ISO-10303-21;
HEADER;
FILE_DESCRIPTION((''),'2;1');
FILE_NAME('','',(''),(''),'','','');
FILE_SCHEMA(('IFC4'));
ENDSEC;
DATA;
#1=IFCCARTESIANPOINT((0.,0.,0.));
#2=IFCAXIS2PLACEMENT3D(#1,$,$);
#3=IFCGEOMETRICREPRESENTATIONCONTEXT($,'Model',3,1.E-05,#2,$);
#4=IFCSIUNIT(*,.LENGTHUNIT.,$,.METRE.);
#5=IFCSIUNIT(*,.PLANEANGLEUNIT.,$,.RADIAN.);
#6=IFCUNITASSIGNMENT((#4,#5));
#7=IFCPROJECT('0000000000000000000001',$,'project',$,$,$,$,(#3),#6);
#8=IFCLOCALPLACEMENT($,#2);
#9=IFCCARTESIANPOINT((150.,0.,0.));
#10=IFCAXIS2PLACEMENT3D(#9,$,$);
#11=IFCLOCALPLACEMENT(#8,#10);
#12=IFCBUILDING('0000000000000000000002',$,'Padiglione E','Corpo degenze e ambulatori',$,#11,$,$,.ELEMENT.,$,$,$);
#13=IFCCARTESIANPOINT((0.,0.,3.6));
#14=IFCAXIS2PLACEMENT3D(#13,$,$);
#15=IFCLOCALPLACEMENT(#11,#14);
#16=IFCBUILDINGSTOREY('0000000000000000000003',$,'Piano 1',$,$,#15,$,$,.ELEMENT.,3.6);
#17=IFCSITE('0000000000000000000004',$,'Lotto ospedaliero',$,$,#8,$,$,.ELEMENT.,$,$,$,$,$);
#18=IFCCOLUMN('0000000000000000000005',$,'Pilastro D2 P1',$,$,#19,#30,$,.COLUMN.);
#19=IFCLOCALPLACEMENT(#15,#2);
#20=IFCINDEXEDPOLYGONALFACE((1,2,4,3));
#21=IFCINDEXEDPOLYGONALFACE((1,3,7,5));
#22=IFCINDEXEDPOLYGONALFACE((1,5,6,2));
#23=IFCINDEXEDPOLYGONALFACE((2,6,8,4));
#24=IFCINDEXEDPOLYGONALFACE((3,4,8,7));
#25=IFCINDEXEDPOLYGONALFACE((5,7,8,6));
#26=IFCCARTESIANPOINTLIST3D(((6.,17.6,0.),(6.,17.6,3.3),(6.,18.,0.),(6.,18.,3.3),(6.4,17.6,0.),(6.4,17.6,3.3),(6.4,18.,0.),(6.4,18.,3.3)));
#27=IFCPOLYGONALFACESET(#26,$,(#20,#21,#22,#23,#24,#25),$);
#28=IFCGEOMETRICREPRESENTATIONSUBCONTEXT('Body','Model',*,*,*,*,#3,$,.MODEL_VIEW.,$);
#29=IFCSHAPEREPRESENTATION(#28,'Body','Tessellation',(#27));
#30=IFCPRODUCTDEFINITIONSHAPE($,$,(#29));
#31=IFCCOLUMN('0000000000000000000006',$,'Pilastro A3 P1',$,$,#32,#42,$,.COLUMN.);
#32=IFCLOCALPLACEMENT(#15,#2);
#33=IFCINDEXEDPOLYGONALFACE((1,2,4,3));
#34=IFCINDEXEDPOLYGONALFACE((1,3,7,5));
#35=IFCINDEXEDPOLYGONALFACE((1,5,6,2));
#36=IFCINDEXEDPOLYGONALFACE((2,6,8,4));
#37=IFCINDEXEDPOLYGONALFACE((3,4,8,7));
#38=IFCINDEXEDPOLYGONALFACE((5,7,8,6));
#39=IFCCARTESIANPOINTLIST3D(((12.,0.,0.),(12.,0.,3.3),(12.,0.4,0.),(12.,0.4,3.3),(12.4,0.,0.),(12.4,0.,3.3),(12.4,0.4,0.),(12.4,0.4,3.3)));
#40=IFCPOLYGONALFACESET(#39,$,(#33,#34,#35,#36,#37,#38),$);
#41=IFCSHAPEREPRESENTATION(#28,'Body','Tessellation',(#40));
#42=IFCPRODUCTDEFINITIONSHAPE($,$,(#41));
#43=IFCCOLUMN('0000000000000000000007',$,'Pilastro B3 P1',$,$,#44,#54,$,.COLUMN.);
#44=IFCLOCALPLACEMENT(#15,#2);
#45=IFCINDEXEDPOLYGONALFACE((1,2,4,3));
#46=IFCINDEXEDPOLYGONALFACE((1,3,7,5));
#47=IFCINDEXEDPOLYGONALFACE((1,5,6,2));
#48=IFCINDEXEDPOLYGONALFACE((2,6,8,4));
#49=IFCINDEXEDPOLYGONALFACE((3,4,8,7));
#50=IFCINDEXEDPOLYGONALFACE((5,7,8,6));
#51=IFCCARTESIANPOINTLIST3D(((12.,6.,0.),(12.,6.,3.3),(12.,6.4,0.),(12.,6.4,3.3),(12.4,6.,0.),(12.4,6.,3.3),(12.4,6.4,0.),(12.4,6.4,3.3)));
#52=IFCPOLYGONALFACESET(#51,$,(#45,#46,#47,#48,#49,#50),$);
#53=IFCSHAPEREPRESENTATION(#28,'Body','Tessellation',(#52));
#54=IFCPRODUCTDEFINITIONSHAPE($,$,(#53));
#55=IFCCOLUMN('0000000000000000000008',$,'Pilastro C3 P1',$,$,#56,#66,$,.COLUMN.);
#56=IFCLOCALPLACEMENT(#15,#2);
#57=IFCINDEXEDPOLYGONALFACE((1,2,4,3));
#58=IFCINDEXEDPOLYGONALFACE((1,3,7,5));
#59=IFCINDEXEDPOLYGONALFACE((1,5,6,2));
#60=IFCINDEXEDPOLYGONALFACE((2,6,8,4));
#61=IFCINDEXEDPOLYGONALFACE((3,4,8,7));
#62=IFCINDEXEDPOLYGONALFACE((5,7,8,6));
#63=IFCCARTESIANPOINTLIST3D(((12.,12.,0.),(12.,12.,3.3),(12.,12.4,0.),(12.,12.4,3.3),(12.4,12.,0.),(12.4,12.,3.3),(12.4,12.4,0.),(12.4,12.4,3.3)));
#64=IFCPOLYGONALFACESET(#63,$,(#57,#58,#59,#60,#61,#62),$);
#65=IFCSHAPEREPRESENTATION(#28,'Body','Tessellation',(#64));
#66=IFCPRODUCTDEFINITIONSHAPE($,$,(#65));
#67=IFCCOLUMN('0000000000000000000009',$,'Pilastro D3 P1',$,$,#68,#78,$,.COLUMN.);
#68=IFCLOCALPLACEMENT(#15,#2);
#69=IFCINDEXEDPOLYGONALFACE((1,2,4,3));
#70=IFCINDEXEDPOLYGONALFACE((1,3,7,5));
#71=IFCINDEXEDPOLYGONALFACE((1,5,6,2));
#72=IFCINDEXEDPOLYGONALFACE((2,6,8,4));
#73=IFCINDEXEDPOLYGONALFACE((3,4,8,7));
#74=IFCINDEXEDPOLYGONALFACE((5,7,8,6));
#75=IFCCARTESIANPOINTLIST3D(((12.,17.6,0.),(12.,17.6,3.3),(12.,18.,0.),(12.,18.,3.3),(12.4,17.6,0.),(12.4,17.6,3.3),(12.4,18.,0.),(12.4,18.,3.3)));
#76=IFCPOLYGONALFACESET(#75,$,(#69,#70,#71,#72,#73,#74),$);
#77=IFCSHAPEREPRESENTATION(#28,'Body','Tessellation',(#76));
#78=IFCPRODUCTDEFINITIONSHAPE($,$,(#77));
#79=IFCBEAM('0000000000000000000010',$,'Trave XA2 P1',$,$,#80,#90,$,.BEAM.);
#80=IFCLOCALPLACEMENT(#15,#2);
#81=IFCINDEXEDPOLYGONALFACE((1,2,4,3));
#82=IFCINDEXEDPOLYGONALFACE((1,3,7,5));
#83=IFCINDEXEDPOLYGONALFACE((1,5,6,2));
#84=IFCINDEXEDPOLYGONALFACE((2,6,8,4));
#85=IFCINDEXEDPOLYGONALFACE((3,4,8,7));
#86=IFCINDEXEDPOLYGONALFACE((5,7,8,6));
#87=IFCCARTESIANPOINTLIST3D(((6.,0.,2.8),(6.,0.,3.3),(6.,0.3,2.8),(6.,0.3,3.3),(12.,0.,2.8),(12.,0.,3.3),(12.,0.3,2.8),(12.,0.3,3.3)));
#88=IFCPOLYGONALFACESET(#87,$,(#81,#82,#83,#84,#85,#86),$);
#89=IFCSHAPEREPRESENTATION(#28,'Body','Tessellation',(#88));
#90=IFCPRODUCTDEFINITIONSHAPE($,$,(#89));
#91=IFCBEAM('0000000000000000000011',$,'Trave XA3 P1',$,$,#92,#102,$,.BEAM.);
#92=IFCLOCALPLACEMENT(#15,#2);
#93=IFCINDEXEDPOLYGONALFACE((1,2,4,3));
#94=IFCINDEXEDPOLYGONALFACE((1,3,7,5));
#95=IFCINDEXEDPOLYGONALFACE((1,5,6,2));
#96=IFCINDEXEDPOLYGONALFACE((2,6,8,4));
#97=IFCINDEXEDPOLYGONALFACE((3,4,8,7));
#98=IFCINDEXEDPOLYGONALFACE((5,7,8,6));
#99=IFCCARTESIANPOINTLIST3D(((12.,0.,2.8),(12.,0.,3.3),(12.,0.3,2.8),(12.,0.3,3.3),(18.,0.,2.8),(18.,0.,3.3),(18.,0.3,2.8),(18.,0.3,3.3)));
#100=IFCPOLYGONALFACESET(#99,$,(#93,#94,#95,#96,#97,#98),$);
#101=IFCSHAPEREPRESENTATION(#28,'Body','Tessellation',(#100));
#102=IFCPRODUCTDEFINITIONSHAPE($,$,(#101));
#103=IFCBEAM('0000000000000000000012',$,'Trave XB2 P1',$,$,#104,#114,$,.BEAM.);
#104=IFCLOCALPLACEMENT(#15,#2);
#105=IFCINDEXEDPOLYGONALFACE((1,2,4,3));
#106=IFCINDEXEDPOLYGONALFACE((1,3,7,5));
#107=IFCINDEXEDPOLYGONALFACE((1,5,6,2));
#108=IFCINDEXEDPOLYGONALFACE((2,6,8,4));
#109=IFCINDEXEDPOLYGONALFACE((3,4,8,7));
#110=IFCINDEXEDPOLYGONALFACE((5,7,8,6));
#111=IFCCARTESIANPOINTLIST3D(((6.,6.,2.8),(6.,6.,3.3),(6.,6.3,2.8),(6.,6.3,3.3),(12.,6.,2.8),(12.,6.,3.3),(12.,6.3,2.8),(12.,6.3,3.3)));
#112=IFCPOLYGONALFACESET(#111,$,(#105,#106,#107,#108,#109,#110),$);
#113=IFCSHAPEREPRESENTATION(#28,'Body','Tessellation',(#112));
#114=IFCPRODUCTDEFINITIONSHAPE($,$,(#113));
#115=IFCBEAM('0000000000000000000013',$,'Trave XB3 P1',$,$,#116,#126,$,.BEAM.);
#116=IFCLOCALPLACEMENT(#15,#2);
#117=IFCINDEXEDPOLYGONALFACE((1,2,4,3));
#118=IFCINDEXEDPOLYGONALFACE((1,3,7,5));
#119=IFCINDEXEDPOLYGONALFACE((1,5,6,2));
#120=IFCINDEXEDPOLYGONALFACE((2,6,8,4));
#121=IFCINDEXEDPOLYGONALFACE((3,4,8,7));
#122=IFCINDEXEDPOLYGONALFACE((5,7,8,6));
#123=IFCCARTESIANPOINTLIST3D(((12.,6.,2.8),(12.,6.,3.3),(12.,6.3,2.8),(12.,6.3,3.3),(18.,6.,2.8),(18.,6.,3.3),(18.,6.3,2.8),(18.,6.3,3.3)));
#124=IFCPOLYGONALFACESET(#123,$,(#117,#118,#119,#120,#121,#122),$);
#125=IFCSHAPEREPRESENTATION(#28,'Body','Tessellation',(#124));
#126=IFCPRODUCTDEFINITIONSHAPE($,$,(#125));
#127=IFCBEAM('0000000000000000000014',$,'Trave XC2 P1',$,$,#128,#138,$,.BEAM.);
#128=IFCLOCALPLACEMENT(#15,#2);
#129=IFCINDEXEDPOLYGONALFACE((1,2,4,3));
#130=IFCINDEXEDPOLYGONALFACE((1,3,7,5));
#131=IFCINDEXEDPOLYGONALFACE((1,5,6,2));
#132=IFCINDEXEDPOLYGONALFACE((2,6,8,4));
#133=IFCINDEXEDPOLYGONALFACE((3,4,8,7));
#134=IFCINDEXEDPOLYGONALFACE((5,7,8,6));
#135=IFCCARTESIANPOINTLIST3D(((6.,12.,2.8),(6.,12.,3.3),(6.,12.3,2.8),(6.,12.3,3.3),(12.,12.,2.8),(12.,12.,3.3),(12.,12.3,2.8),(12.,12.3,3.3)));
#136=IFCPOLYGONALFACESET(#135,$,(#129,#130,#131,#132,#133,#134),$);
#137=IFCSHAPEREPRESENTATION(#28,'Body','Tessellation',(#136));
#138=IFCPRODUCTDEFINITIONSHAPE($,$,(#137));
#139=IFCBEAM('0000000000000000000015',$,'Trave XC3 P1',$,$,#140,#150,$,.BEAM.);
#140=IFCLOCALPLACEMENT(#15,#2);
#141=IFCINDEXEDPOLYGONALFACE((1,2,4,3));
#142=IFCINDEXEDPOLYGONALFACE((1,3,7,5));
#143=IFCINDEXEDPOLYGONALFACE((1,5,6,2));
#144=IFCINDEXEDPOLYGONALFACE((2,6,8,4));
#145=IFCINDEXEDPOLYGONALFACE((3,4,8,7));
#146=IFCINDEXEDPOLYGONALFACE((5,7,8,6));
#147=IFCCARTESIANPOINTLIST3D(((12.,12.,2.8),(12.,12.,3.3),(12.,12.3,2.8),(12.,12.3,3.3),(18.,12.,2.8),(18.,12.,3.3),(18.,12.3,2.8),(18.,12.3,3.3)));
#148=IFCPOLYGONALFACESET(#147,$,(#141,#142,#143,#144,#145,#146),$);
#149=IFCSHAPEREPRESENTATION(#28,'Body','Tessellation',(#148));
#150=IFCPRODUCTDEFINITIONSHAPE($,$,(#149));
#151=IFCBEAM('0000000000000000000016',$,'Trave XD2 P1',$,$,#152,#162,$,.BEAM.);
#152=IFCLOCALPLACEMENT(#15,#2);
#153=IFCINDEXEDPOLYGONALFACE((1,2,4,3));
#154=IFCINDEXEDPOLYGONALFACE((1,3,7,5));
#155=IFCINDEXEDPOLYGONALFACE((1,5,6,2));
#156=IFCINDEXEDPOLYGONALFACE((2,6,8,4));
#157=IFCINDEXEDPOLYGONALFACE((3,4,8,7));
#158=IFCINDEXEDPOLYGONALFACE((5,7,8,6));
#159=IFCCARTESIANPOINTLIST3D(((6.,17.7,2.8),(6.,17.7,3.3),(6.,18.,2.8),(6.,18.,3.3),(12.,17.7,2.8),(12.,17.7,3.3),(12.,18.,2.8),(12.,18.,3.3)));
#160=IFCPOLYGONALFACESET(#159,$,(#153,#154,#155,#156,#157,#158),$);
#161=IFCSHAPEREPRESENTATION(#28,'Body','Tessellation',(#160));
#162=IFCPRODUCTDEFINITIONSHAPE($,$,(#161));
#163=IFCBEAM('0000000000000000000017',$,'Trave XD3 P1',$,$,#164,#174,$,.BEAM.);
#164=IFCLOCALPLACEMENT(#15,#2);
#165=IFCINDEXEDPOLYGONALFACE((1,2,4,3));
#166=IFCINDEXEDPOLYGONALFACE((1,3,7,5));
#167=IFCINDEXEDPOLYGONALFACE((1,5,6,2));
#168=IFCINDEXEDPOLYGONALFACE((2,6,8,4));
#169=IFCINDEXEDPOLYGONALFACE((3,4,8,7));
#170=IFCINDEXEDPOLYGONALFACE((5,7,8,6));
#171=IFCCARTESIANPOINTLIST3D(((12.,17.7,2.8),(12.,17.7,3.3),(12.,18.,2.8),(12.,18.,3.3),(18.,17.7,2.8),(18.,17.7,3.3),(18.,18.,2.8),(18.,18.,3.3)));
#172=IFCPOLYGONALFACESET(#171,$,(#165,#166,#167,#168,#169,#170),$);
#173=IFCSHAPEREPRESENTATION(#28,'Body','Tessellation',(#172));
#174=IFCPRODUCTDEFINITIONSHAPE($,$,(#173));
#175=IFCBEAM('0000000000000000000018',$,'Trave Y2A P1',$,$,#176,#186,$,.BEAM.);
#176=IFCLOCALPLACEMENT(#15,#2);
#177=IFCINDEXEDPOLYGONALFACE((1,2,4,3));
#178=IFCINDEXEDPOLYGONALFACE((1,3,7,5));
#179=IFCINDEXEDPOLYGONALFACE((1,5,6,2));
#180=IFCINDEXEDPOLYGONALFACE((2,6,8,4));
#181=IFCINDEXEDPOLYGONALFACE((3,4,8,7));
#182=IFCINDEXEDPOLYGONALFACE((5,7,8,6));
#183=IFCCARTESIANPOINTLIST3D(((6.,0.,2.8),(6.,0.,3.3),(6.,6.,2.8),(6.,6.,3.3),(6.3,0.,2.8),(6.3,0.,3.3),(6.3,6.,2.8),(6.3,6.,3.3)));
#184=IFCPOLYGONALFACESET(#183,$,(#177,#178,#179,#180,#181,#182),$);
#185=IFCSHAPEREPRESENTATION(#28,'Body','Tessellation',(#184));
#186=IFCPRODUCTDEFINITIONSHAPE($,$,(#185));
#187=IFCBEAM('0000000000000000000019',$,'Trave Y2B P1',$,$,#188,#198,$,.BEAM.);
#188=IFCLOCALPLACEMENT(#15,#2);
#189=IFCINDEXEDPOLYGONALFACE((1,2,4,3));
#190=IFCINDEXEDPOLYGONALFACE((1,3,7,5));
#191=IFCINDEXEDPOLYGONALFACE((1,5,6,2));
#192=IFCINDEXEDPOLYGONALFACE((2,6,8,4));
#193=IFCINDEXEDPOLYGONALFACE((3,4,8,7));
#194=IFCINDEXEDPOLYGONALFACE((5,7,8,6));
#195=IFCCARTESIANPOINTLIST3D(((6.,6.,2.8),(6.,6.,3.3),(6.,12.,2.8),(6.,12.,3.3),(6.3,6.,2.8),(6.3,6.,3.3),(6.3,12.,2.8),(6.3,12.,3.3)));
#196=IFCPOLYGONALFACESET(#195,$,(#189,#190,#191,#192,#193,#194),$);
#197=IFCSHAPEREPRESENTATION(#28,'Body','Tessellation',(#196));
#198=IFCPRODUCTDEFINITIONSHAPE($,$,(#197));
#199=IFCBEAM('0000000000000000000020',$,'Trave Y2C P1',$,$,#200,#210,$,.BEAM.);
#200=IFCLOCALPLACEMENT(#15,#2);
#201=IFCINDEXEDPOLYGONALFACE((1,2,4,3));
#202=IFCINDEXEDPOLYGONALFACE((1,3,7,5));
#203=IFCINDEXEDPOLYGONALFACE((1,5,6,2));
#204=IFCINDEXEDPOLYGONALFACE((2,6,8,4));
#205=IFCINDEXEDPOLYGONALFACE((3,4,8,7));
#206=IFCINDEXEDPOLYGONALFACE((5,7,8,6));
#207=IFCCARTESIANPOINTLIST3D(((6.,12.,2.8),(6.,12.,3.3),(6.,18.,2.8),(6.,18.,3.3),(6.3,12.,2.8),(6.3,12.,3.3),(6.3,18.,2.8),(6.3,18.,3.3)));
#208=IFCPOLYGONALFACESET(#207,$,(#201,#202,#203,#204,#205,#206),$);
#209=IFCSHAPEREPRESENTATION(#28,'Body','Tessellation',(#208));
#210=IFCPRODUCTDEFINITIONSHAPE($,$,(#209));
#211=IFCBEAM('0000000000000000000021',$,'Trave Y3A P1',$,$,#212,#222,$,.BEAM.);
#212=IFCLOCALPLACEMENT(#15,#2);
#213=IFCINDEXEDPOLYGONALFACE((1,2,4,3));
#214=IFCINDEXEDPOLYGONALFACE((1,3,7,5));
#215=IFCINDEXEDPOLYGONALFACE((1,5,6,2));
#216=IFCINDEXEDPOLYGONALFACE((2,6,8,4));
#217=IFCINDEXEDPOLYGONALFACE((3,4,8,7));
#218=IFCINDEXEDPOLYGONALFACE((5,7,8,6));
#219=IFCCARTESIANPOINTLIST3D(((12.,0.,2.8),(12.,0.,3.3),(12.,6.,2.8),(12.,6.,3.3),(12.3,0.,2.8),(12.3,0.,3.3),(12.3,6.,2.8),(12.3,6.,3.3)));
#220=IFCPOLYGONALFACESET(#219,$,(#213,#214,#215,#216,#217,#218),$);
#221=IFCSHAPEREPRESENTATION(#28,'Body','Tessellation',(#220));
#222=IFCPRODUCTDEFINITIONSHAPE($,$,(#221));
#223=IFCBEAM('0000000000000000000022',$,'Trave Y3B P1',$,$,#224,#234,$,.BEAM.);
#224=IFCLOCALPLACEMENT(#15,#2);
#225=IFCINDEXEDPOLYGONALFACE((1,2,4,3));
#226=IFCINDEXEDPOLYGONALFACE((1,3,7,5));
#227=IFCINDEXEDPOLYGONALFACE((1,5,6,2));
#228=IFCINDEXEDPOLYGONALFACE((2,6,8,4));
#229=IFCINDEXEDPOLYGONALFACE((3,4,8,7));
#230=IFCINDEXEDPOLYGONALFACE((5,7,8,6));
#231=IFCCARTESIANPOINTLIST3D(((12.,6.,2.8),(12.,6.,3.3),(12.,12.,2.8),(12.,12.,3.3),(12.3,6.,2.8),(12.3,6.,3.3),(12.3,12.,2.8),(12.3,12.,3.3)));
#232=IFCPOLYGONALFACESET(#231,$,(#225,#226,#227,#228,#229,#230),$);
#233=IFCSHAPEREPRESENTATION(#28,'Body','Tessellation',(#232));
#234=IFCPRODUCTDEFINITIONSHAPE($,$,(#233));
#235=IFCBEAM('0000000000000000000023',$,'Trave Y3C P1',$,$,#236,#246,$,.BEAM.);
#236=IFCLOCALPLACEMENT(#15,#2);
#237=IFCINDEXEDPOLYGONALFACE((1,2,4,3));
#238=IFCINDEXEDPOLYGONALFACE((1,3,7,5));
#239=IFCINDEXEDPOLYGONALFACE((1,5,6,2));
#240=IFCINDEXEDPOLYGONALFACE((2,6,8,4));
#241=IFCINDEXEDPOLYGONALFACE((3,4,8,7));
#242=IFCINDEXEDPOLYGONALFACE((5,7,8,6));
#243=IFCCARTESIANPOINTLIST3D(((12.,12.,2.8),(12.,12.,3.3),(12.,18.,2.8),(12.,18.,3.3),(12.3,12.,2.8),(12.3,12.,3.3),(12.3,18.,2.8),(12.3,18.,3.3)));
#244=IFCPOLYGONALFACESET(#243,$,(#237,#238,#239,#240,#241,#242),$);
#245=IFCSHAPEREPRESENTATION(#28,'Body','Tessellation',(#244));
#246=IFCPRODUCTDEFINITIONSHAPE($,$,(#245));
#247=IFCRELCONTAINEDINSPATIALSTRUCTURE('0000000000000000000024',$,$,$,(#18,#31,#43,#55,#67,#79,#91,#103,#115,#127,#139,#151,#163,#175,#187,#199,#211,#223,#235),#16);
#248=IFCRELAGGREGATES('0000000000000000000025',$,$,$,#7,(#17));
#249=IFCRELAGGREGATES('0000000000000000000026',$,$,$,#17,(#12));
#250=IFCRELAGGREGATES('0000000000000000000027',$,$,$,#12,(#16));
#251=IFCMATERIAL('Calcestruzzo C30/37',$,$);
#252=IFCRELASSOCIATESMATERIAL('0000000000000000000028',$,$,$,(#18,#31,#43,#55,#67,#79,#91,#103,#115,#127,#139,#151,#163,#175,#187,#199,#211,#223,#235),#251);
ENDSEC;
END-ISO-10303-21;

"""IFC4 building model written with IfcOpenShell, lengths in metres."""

from ifc_helpers import new_model, si_unit, frame, frame_2d, origin, place, context, subcontext, project, spatial, rectangle, extrude, material, element, save


model = new_model("IFC4")

# Units and contexts
model_context = context("Model", 3, precision=1e-05, world=origin())
body_context = subcontext(model_context, "Body", "Model", "MODEL_VIEW")
ifc_project = project(units=[si_unit("LENGTHUNIT", "METRE"), si_unit("PLANEANGLEUNIT", "RADIAN")], contexts=[model_context])

# Site, building, storey
site_placement = place(None, origin())
site = spatial("IfcSite", under=ifc_project, at=site_placement, Name="Lotto ospedaliero", CompositionType="ELEMENT")
building_placement = place(site_placement, frame((150.0, 0.0, 0.0)))
building = spatial("IfcBuilding", under=site, at=building_placement, Name="Padiglione E", Description="Corpo degenze e ambulatori", CompositionType="ELEMENT")
storey_placement = place(building_placement, frame((0.0, 0.0, 3.6)))
storey = spatial("IfcBuildingStorey", under=building, at=storey_placement, Name="Piano 1", CompositionType="ELEMENT", Elevation=3.6)

# Columns
ifc_material_1 = material(Name="Calcestruzzo C30/37")
for number, where, name in (
    (1, (6.0, 17.6, 0.0), "Pilastro D2 P1"),
    (2, (12.0, 0.0, 0.0), "Pilastro A3 P1"),
    (3, (12.0, 6.0, 0.0), "Pilastro B3 P1"),
    (4, (12.0, 12.0, 0.0), "Pilastro C3 P1"),
    (5, (12.0, 17.6, 0.0), "Pilastro D3 P1"),
):
    element("IfcColumn", number, at=place(storey_placement, frame(where)), inside=storey, material=ifc_material_1, Name=name, PredefinedType="COLUMN", context=body_context, shape_type="SweptSolid", body=[
        extrude(rectangle(XDim=0.4, YDim=0.4, at=frame_2d((0.2, 0.2))), origin(), (0.0, 0.0, 1.0), 3.3),
    ])

# Beams
for number, where, name in (
    (6, (6.0, 0.0, 2.8), "Trave XA2 P1"),
    (7, (12.0, 0.0, 2.8), "Trave XA3 P1"),
    (8, (6.0, 6.0, 2.8), "Trave XB2 P1"),
    (9, (12.0, 6.0, 2.8), "Trave XB3 P1"),
    (10, (6.0, 12.0, 2.8), "Trave XC2 P1"),
    (11, (12.0, 12.0, 2.8), "Trave XC3 P1"),
    (12, (6.0, 17.7, 2.8), "Trave XD2 P1"),
    (13, (12.0, 17.7, 2.8), "Trave XD3 P1"),
):
    element("IfcBeam", number, at=place(storey_placement, frame(where)), inside=storey, material=ifc_material_1, Name=name, PredefinedType="BEAM", context=body_context, shape_type="SweptSolid", body=[
        extrude(rectangle(XDim=6.0, YDim=0.3, at=frame_2d((3.0, 0.15))), origin(), (0.0, 0.0, 1.0), 0.5),
    ])
for number, where, name in (
    (14, (6.0, 0.0, 2.8), "Trave Y2A P1"),
    (15, (6.0, 6.0, 2.8), "Trave Y2B P1"),
    (16, (6.0, 12.0, 2.8), "Trave Y2C P1"),
    (17, (12.0, 0.0, 2.8), "Trave Y3A P1"),
    (18, (12.0, 6.0, 2.8), "Trave Y3B P1"),
    (19, (12.0, 12.0, 2.8), "Trave Y3C P1"),
):
    element("IfcBeam", number, at=place(storey_placement, frame(where)), inside=storey, material=ifc_material_1, Name=name, PredefinedType="BEAM", context=body_context, shape_type="SweptSolid", body=[
        extrude(rectangle(XDim=0.3, YDim=6.0, at=frame_2d((0.15, 3.0))), origin(), (0.0, 0.0, 1.0), 0.5),
    ])

save(model, "model.ifc")
